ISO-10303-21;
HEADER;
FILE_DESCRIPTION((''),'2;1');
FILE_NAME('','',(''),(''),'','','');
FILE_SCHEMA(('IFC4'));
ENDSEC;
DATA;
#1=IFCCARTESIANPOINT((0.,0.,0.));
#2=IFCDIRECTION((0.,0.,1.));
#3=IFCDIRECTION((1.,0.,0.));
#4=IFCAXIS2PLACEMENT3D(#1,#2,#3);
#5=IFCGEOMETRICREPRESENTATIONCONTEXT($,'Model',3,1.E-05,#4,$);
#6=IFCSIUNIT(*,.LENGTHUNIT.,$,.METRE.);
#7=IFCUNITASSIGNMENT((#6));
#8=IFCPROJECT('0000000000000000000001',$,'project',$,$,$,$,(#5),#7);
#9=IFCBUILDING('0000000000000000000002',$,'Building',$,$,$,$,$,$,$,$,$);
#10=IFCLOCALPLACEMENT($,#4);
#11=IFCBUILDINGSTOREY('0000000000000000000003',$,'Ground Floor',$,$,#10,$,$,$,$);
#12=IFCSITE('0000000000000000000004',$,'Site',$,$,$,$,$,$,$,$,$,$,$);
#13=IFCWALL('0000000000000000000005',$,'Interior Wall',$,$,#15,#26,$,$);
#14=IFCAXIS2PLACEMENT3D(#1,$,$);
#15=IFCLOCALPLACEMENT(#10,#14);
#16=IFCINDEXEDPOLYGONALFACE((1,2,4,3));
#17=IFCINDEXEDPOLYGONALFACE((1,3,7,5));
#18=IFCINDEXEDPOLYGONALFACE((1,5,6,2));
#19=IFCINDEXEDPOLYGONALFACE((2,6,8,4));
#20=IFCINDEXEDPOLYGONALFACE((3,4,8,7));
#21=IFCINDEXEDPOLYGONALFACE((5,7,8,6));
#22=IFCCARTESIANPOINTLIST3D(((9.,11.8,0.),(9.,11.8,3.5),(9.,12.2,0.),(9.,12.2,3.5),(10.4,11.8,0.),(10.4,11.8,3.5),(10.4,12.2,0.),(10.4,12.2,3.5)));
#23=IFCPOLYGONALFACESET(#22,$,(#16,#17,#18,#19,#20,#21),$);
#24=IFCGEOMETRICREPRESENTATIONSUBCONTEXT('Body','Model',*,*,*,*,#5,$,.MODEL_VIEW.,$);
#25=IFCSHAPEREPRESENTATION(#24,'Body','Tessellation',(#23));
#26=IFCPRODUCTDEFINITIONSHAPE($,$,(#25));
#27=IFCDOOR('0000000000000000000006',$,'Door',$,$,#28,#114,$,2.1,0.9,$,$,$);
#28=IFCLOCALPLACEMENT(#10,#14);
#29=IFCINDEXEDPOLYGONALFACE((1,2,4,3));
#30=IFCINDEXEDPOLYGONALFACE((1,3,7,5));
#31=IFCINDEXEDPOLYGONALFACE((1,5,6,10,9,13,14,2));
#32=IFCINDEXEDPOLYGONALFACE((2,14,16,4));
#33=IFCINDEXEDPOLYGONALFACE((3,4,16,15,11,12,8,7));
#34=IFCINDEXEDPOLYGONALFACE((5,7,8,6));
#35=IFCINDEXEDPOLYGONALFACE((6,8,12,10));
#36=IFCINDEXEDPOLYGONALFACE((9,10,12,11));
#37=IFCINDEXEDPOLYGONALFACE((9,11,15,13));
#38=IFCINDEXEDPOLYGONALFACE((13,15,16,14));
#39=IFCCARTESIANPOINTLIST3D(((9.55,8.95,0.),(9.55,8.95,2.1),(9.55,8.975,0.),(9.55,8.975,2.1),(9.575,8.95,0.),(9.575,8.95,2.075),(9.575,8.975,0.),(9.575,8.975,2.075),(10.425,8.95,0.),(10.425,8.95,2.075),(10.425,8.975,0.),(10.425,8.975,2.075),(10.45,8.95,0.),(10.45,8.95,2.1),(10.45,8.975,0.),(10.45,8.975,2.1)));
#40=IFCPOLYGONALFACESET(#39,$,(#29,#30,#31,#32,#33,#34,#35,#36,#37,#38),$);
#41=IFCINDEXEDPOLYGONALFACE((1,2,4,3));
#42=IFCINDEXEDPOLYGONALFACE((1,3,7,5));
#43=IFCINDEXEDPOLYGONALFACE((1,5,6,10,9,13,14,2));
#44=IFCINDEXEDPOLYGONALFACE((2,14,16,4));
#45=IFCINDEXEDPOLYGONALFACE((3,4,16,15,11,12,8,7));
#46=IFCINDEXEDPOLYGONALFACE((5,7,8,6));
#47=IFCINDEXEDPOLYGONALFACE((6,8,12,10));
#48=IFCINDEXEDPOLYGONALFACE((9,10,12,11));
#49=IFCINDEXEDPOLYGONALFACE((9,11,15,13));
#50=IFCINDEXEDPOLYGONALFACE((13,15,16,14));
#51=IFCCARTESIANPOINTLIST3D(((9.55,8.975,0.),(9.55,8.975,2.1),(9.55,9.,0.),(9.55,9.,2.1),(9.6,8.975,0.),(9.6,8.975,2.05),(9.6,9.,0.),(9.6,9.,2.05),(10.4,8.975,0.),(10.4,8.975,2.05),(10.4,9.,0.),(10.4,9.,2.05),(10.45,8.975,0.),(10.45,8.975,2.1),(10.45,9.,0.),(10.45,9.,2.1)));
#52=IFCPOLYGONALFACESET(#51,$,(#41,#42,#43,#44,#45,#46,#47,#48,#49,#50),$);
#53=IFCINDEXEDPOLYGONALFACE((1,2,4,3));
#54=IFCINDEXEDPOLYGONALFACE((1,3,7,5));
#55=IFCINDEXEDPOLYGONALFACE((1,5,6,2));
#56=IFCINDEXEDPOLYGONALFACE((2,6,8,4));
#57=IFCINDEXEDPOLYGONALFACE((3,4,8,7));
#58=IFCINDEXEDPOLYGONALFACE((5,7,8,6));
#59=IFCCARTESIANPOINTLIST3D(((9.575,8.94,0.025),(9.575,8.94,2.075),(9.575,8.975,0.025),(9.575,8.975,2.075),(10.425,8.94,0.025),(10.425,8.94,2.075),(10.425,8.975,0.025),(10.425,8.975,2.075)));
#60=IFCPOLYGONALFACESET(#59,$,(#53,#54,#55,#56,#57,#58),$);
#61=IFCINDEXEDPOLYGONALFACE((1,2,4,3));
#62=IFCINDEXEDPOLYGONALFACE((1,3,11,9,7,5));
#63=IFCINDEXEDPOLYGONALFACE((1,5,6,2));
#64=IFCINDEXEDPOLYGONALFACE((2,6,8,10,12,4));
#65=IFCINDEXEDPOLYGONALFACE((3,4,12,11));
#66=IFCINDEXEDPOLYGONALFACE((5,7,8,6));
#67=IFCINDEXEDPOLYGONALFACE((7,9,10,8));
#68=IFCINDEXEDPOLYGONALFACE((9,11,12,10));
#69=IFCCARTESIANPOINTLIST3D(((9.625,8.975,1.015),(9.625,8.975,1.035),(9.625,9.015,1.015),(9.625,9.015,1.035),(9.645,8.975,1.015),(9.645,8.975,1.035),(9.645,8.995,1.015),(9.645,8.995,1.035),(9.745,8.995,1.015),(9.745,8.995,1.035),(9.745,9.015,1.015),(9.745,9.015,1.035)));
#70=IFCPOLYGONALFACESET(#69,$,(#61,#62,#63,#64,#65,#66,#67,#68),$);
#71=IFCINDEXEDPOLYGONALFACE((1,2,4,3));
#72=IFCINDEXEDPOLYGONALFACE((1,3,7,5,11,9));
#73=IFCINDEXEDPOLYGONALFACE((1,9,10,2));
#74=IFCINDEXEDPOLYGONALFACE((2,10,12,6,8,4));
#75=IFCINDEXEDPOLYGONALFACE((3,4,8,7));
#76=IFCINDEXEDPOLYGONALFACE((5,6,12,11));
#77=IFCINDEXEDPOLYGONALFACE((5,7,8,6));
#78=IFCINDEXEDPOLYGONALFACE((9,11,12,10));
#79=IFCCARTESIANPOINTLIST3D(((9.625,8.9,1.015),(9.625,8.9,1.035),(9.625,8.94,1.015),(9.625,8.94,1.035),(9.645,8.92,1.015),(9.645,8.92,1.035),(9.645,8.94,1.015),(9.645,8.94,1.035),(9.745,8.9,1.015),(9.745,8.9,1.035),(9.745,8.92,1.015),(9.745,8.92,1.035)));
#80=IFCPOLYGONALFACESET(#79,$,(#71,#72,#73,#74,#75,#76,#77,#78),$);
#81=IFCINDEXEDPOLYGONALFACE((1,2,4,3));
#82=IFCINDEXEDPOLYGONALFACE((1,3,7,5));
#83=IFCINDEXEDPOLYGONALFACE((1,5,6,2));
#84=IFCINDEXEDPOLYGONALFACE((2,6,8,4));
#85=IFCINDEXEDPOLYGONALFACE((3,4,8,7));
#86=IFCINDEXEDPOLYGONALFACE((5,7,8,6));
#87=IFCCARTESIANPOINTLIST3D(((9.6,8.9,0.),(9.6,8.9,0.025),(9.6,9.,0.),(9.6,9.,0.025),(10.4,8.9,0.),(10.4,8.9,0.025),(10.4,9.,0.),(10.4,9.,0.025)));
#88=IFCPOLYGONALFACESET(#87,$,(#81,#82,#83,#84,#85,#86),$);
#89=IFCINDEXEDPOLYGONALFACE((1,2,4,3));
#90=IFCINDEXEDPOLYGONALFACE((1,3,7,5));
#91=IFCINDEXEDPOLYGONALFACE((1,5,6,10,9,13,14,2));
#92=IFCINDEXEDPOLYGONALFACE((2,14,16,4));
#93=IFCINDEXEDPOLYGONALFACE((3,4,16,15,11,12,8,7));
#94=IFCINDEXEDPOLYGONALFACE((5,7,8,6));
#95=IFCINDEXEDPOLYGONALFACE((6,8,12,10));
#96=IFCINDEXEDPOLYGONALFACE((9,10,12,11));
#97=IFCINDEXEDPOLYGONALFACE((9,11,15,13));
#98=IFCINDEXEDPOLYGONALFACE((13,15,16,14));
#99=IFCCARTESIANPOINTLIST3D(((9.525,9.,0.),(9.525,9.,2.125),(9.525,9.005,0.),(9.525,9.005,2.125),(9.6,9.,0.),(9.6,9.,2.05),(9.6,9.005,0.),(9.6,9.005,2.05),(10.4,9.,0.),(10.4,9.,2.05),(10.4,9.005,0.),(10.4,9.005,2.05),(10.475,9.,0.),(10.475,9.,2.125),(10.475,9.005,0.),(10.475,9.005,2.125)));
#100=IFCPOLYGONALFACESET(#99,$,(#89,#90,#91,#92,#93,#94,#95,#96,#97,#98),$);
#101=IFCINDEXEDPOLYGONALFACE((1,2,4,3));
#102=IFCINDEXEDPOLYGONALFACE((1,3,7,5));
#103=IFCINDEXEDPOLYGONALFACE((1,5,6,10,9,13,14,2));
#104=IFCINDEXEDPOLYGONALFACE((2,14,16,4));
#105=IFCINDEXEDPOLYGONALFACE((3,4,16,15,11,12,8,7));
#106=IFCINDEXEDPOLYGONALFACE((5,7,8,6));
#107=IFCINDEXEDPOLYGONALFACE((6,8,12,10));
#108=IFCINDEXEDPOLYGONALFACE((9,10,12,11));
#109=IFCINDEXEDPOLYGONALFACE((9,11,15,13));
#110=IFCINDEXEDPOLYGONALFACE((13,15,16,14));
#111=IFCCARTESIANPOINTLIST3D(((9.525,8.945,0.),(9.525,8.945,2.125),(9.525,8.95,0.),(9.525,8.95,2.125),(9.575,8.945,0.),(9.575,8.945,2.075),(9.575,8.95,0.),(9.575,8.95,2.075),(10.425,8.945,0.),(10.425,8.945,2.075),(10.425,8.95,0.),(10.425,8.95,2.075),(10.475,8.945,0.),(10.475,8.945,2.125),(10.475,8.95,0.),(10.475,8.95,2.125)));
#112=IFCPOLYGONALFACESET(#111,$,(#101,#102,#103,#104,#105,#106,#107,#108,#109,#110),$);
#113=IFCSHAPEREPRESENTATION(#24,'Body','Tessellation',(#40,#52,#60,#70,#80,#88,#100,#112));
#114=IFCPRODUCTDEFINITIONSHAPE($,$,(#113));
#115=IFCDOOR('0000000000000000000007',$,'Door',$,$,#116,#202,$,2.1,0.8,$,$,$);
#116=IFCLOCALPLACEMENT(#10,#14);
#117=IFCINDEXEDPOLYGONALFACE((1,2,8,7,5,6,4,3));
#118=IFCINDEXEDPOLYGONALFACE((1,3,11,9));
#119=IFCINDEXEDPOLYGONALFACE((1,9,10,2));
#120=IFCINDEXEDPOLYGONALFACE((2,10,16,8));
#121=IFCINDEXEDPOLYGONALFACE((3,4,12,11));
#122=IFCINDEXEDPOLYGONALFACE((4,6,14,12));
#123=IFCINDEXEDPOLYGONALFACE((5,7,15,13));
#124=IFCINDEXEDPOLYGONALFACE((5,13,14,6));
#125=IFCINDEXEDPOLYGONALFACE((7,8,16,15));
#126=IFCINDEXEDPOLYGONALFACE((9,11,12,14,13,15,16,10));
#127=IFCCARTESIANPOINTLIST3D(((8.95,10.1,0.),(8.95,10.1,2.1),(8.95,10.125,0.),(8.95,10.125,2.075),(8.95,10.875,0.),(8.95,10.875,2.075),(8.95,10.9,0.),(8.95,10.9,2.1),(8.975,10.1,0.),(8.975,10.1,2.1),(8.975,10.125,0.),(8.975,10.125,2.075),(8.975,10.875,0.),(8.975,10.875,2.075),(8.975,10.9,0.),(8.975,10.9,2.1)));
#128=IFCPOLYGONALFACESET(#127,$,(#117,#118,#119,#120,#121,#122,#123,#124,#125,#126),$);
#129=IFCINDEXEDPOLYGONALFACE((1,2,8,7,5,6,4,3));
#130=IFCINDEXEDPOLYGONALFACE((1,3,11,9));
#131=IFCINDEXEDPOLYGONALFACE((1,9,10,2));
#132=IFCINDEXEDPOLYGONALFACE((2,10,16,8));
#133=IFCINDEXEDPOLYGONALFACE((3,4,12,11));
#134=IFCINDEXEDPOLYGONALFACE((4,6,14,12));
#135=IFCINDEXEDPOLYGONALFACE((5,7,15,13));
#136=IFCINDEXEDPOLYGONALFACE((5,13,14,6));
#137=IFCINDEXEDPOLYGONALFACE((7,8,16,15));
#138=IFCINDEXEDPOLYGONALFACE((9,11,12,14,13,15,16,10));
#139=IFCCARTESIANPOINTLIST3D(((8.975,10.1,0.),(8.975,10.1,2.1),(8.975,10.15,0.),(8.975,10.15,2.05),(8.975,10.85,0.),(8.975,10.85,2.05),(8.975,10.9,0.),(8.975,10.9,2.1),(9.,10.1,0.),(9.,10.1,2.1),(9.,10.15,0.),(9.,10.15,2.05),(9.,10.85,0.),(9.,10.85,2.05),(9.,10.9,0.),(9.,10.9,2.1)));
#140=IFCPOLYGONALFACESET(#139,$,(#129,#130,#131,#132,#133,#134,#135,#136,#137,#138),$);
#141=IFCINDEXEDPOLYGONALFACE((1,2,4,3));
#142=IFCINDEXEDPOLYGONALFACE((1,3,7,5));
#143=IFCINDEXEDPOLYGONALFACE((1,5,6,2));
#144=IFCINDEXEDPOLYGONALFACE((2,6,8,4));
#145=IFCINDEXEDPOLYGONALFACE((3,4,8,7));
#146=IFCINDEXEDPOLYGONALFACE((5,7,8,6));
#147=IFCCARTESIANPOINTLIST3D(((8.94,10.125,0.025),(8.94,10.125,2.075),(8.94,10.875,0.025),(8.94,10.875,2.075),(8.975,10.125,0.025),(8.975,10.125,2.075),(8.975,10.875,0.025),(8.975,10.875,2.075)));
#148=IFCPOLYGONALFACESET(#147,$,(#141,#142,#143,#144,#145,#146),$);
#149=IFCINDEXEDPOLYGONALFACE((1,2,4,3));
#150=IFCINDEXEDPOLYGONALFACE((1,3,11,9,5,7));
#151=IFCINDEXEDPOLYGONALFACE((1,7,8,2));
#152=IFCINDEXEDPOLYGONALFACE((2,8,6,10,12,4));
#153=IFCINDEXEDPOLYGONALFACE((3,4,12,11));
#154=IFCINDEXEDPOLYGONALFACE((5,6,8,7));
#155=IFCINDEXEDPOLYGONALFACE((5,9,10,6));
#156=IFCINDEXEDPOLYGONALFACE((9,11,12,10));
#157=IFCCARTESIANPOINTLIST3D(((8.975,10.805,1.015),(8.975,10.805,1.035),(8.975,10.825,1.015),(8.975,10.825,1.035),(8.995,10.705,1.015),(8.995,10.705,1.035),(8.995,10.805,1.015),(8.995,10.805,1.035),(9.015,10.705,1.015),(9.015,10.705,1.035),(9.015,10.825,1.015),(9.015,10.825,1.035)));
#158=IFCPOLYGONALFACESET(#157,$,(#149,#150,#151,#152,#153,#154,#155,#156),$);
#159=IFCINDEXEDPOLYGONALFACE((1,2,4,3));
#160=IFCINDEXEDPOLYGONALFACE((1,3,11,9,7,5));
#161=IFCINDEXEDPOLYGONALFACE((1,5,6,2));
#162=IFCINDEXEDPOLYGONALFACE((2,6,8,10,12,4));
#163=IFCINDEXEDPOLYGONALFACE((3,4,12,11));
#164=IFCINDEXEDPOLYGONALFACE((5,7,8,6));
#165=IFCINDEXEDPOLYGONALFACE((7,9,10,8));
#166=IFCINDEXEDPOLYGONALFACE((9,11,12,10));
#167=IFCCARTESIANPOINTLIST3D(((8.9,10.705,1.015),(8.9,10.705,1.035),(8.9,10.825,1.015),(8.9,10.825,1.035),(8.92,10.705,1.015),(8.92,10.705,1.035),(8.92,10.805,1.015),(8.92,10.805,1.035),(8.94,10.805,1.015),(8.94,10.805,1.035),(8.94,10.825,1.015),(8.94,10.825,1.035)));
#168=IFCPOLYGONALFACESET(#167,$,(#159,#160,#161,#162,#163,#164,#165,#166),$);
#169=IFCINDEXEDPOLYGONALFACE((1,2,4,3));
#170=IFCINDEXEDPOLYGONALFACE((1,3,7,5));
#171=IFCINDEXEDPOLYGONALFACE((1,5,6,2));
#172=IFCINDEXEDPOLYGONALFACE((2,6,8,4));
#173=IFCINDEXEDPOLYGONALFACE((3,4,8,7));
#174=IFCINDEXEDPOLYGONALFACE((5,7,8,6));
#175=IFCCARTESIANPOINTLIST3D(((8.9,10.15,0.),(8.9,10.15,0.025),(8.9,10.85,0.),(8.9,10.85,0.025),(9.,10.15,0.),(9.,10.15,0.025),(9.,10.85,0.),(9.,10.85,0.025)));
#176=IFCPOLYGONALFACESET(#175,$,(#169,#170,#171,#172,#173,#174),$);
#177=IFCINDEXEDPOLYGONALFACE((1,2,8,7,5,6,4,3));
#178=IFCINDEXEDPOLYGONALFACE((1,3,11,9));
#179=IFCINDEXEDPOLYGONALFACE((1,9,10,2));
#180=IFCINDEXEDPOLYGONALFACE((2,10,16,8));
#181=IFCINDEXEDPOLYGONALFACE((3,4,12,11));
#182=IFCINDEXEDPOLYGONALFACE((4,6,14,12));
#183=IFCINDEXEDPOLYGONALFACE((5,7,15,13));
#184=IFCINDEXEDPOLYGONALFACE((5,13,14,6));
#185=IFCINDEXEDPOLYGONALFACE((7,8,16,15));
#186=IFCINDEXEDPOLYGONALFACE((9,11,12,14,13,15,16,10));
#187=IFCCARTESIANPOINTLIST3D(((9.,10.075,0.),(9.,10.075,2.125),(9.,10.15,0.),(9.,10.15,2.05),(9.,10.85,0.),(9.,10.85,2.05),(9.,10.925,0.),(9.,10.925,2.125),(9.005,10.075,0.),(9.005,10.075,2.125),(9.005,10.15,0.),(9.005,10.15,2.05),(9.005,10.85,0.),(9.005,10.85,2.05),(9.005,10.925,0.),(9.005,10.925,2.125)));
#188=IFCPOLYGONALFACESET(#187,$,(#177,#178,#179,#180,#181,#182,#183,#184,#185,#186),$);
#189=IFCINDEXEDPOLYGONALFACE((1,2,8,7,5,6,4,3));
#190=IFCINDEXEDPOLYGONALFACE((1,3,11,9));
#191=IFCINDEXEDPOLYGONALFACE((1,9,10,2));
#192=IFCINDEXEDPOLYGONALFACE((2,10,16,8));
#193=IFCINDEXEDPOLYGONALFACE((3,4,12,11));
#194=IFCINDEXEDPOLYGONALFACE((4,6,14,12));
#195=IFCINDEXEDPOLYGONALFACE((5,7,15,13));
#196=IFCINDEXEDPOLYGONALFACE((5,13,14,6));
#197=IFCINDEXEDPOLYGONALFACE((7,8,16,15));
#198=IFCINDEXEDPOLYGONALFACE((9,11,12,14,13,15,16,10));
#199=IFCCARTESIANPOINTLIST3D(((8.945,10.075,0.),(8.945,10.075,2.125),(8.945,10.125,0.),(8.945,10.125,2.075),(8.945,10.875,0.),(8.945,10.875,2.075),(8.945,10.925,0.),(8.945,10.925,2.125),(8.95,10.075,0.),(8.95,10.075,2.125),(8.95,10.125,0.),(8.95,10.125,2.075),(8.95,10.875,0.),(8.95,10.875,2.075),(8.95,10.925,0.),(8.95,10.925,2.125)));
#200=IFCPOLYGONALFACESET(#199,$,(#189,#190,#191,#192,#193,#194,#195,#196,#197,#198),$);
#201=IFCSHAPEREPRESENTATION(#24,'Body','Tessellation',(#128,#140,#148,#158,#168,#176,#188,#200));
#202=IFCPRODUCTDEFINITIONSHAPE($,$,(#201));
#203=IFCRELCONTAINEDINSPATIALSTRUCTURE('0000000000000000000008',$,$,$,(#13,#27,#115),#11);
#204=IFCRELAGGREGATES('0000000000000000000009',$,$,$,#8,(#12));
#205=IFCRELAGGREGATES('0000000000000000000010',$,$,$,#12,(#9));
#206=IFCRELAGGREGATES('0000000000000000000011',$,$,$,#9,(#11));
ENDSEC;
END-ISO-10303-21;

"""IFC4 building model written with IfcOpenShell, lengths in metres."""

from ifc_helpers import new_model, si_unit, frame, origin_with_axes, place, context, subcontext, project, spatial, line, indexed_curve, outline, extrude, element, save


model = new_model("IFC4")

# Units and contexts
model_context = context("Model", 3, precision=1e-05, world=origin_with_axes())
body_context = subcontext(model_context, "Body", "Model", "MODEL_VIEW")
ifc_project = project(units=[si_unit("LENGTHUNIT", "METRE")], contexts=[model_context])

# Site, building, storey
site = spatial("IfcSite", under=ifc_project, Name="Site")
building = spatial("IfcBuilding", under=site, Name="Building")
storey_placement = place(None, origin_with_axes())
storey = spatial("IfcBuildingStorey", under=building, at=storey_placement, Name="Ground Floor")

# Wall
wall_1_placement = place(storey_placement, frame((10.4, 12.0, 0.0), z_axis=(0.0, 0.0, 1.0), x_axis=(-1.0, 0.0, 0.0)))
element("IfcWall", 1, at=wall_1_placement, inside=storey, Name="Interior Wall", context=body_context, shape_type="SweptSolid", body=[
    extrude(outline(indexed_curve([(0.0, 0.0), (0.0, 0.4), (1.4, 0.4), (1.4, 0.0), (0.0, 0.0)], self_intersect=False)), frame((0.0, -0.2, 0.0), z_axis=(0.0, 0.0, 1.0), x_axis=(1.0, 0.0, 0.0)), (0.0, 0.0, 1.0), 3.5),
])

# Doors
door_1_placement = place(storey_placement, frame((10.45, 9.0, 0.0), z_axis=(0.0, 0.0, 1.0), x_axis=(-1.0, 0.0, 0.0)))
element("IfcDoor", 2, at=door_1_placement, inside=storey, Name="Door", OverallHeight=2.1, OverallWidth=0.9, context=body_context, shape_type="SweptSolid", body=[
    extrude(outline(indexed_curve([(0.0, 0.0), (0.0, 2.1), (0.9, 2.1), (0.9, 0.0), (0.875, 0.0), (0.875, 2.075), (0.025, 2.075), (0.025, 0.0)], segments=[line(1, 2, 3, 4, 5, 6, 7, 8, 1)])), frame((0.0, 0.025, 0.0), z_axis=(0.0, -1.0, 0.0), x_axis=(1.0, 0.0, 0.0)), (0.0, 0.0, -1.0), 0.025),
    extrude(outline(indexed_curve([(0.0, 0.0), (0.0, 2.1), (0.9, 2.1), (0.9, 0.0), (0.85, 0.0), (0.85, 2.05), (0.05, 2.05), (0.05, 0.0)], segments=[line(1, 2, 3, 4, 5, 6, 7, 8, 1)])), frame((0.0, 0.0, 0.0), z_axis=(0.0, -1.0, 0.0), x_axis=(1.0, 0.0, 0.0)), (0.0, 0.0, -1.0), 0.025),
    extrude(outline(indexed_curve([(0.0, 0.0), (0.85, 0.0), (0.85, 0.035), (0.0, 0.035)], segments=[line(1, 2, 3, 4, 1)])), frame((0.025, 0.025, 0.025), z_axis=(0.0, 0.0, 1.0), x_axis=(1.0, 0.0, 0.0)), (0.0, 0.0, 1.0), 2.05),
    extrude(outline(indexed_curve([(0.0, 0.0), (0.0, -0.04), (-0.12, -0.04), (-0.12, -0.02), (-0.02, -0.02), (-0.02, 0.0)], segments=[line(1, 2, 3, 4, 5, 6, 1)])), frame((0.825, 0.025, 1.015), z_axis=(0.0, 0.0, 1.0), x_axis=(1.0, 0.0, 0.0)), (0.0, 0.0, 1.0), 0.02),
    extrude(outline(indexed_curve([(0.0, 0.0), (0.0, 0.04), (-0.12, 0.04), (-0.12, 0.02), (-0.02, 0.02), (-0.02, 0.0)], segments=[line(1, 2, 3, 4, 5, 6, 1)])), frame((0.825, 0.06, 1.015), z_axis=(0.0, 0.0, 1.0), x_axis=(1.0, 0.0, 0.0)), (0.0, 0.0, 1.0), 0.02),
    extrude(outline(indexed_curve([(0.0, 0.0), (0.8, 0.0), (0.8, 0.1), (0.0, 0.1)], segments=[line(1, 2, 3, 4, 1)])), frame((0.05, 0.0, 0.0), z_axis=(0.0, 0.0, 1.0), x_axis=(1.0, 0.0, 0.0)), (0.0, 0.0, 1.0), 0.025),
    extrude(outline(indexed_curve([(0.0, 0.0), (0.0, 2.125), (0.95, 2.125), (0.95, 0.0), (0.875, 0.0), (0.875, 2.05), (0.075, 2.05), (0.075, 0.0)], segments=[line(1, 2, 3, 4, 5, 6, 7, 8, 1)])), frame((-0.025, -0.005, 0.0), z_axis=(0.0, -1.0, 0.0), x_axis=(1.0, 0.0, 0.0)), (0.0, 0.0, -1.0), 0.005),
    extrude(outline(indexed_curve([(0.0, 0.0), (0.0, 2.125), (0.95, 2.125), (0.95, 0.0), (0.9, 0.0), (0.9, 2.075), (0.05, 2.075), (0.05, 0.0)], segments=[line(1, 2, 3, 4, 5, 6, 7, 8, 1)])), frame((-0.025, 0.05, 0.0), z_axis=(0.0, -1.0, 0.0), x_axis=(1.0, 0.0, 0.0)), (0.0, 0.0, -1.0), 0.005),
])
door_2_placement = place(storey_placement, frame((9.0, 10.1, 0.0), z_axis=(0.0, 0.0, 1.0), x_axis=(0.0, 1.0, 0.0)))
element("IfcDoor", 3, at=door_2_placement, inside=storey, Name="Door", OverallHeight=2.1, OverallWidth=0.8, context=body_context, shape_type="SweptSolid", body=[
    extrude(outline(indexed_curve([(0.0, 0.0), (0.0, 2.1), (0.8, 2.1), (0.8, 0.0), (0.775, 0.0), (0.775, 2.075), (0.025, 2.075), (0.025, 0.0)], segments=[line(1, 2, 3, 4, 5, 6, 7, 8, 1)])), frame((0.0, 0.025, 0.0), z_axis=(0.0, -1.0, 0.0), x_axis=(1.0, 0.0, 0.0)), (0.0, 0.0, -1.0), 0.025),
    extrude(outline(indexed_curve([(0.0, 0.0), (0.0, 2.1), (0.8, 2.1), (0.8, 0.0), (0.75, 0.0), (0.75, 2.05), (0.05, 2.05), (0.05, 0.0)], segments=[line(1, 2, 3, 4, 5, 6, 7, 8, 1)])), frame((0.0, 0.0, 0.0), z_axis=(0.0, -1.0, 0.0), x_axis=(1.0, 0.0, 0.0)), (0.0, 0.0, -1.0), 0.025),
    extrude(outline(indexed_curve([(0.0, 0.0), (0.75, 0.0), (0.75, 0.035), (0.0, 0.035)], segments=[line(1, 2, 3, 4, 1)])), frame((0.025, 0.025, 0.025), z_axis=(0.0, 0.0, 1.0), x_axis=(1.0, 0.0, 0.0)), (0.0, 0.0, 1.0), 2.05),
    extrude(outline(indexed_curve([(0.0, 0.0), (0.0, -0.04), (-0.12, -0.04), (-0.12, -0.02), (-0.02, -0.02), (-0.02, 0.0)], segments=[line(1, 2, 3, 4, 5, 6, 1)])), frame((0.725, 0.025, 1.015), z_axis=(0.0, 0.0, 1.0), x_axis=(1.0, 0.0, 0.0)), (0.0, 0.0, 1.0), 0.02),
    extrude(outline(indexed_curve([(0.0, 0.0), (0.0, 0.04), (-0.12, 0.04), (-0.12, 0.02), (-0.02, 0.02), (-0.02, 0.0)], segments=[line(1, 2, 3, 4, 5, 6, 1)])), frame((0.725, 0.06, 1.015), z_axis=(0.0, 0.0, 1.0), x_axis=(1.0, 0.0, 0.0)), (0.0, 0.0, 1.0), 0.02),
    extrude(outline(indexed_curve([(0.0, 0.0), (0.7, 0.0), (0.7, 0.1), (0.0, 0.1)], segments=[line(1, 2, 3, 4, 1)])), frame((0.05, 0.0, 0.0), z_axis=(0.0, 0.0, 1.0), x_axis=(1.0, 0.0, 0.0)), (0.0, 0.0, 1.0), 0.025),
    extrude(outline(indexed_curve([(0.0, 0.0), (0.0, 2.125), (0.85, 2.125), (0.85, 0.0), (0.775, 0.0), (0.775, 2.05), (0.075, 2.05), (0.075, 0.0)], segments=[line(1, 2, 3, 4, 5, 6, 7, 8, 1)])), frame((-0.025, -0.005, 0.0), z_axis=(0.0, -1.0, 0.0), x_axis=(1.0, 0.0, 0.0)), (0.0, 0.0, -1.0), 0.005),
    extrude(outline(indexed_curve([(0.0, 0.0), (0.0, 2.125), (0.85, 2.125), (0.85, 0.0), (0.8, 0.0), (0.8, 2.075), (0.05, 2.075), (0.05, 0.0)], segments=[line(1, 2, 3, 4, 5, 6, 7, 8, 1)])), frame((-0.025, 0.05, 0.0), z_axis=(0.0, -1.0, 0.0), x_axis=(1.0, 0.0, 0.0)), (0.0, 0.0, -1.0), 0.005),
])

save(model, "model.ifc")
